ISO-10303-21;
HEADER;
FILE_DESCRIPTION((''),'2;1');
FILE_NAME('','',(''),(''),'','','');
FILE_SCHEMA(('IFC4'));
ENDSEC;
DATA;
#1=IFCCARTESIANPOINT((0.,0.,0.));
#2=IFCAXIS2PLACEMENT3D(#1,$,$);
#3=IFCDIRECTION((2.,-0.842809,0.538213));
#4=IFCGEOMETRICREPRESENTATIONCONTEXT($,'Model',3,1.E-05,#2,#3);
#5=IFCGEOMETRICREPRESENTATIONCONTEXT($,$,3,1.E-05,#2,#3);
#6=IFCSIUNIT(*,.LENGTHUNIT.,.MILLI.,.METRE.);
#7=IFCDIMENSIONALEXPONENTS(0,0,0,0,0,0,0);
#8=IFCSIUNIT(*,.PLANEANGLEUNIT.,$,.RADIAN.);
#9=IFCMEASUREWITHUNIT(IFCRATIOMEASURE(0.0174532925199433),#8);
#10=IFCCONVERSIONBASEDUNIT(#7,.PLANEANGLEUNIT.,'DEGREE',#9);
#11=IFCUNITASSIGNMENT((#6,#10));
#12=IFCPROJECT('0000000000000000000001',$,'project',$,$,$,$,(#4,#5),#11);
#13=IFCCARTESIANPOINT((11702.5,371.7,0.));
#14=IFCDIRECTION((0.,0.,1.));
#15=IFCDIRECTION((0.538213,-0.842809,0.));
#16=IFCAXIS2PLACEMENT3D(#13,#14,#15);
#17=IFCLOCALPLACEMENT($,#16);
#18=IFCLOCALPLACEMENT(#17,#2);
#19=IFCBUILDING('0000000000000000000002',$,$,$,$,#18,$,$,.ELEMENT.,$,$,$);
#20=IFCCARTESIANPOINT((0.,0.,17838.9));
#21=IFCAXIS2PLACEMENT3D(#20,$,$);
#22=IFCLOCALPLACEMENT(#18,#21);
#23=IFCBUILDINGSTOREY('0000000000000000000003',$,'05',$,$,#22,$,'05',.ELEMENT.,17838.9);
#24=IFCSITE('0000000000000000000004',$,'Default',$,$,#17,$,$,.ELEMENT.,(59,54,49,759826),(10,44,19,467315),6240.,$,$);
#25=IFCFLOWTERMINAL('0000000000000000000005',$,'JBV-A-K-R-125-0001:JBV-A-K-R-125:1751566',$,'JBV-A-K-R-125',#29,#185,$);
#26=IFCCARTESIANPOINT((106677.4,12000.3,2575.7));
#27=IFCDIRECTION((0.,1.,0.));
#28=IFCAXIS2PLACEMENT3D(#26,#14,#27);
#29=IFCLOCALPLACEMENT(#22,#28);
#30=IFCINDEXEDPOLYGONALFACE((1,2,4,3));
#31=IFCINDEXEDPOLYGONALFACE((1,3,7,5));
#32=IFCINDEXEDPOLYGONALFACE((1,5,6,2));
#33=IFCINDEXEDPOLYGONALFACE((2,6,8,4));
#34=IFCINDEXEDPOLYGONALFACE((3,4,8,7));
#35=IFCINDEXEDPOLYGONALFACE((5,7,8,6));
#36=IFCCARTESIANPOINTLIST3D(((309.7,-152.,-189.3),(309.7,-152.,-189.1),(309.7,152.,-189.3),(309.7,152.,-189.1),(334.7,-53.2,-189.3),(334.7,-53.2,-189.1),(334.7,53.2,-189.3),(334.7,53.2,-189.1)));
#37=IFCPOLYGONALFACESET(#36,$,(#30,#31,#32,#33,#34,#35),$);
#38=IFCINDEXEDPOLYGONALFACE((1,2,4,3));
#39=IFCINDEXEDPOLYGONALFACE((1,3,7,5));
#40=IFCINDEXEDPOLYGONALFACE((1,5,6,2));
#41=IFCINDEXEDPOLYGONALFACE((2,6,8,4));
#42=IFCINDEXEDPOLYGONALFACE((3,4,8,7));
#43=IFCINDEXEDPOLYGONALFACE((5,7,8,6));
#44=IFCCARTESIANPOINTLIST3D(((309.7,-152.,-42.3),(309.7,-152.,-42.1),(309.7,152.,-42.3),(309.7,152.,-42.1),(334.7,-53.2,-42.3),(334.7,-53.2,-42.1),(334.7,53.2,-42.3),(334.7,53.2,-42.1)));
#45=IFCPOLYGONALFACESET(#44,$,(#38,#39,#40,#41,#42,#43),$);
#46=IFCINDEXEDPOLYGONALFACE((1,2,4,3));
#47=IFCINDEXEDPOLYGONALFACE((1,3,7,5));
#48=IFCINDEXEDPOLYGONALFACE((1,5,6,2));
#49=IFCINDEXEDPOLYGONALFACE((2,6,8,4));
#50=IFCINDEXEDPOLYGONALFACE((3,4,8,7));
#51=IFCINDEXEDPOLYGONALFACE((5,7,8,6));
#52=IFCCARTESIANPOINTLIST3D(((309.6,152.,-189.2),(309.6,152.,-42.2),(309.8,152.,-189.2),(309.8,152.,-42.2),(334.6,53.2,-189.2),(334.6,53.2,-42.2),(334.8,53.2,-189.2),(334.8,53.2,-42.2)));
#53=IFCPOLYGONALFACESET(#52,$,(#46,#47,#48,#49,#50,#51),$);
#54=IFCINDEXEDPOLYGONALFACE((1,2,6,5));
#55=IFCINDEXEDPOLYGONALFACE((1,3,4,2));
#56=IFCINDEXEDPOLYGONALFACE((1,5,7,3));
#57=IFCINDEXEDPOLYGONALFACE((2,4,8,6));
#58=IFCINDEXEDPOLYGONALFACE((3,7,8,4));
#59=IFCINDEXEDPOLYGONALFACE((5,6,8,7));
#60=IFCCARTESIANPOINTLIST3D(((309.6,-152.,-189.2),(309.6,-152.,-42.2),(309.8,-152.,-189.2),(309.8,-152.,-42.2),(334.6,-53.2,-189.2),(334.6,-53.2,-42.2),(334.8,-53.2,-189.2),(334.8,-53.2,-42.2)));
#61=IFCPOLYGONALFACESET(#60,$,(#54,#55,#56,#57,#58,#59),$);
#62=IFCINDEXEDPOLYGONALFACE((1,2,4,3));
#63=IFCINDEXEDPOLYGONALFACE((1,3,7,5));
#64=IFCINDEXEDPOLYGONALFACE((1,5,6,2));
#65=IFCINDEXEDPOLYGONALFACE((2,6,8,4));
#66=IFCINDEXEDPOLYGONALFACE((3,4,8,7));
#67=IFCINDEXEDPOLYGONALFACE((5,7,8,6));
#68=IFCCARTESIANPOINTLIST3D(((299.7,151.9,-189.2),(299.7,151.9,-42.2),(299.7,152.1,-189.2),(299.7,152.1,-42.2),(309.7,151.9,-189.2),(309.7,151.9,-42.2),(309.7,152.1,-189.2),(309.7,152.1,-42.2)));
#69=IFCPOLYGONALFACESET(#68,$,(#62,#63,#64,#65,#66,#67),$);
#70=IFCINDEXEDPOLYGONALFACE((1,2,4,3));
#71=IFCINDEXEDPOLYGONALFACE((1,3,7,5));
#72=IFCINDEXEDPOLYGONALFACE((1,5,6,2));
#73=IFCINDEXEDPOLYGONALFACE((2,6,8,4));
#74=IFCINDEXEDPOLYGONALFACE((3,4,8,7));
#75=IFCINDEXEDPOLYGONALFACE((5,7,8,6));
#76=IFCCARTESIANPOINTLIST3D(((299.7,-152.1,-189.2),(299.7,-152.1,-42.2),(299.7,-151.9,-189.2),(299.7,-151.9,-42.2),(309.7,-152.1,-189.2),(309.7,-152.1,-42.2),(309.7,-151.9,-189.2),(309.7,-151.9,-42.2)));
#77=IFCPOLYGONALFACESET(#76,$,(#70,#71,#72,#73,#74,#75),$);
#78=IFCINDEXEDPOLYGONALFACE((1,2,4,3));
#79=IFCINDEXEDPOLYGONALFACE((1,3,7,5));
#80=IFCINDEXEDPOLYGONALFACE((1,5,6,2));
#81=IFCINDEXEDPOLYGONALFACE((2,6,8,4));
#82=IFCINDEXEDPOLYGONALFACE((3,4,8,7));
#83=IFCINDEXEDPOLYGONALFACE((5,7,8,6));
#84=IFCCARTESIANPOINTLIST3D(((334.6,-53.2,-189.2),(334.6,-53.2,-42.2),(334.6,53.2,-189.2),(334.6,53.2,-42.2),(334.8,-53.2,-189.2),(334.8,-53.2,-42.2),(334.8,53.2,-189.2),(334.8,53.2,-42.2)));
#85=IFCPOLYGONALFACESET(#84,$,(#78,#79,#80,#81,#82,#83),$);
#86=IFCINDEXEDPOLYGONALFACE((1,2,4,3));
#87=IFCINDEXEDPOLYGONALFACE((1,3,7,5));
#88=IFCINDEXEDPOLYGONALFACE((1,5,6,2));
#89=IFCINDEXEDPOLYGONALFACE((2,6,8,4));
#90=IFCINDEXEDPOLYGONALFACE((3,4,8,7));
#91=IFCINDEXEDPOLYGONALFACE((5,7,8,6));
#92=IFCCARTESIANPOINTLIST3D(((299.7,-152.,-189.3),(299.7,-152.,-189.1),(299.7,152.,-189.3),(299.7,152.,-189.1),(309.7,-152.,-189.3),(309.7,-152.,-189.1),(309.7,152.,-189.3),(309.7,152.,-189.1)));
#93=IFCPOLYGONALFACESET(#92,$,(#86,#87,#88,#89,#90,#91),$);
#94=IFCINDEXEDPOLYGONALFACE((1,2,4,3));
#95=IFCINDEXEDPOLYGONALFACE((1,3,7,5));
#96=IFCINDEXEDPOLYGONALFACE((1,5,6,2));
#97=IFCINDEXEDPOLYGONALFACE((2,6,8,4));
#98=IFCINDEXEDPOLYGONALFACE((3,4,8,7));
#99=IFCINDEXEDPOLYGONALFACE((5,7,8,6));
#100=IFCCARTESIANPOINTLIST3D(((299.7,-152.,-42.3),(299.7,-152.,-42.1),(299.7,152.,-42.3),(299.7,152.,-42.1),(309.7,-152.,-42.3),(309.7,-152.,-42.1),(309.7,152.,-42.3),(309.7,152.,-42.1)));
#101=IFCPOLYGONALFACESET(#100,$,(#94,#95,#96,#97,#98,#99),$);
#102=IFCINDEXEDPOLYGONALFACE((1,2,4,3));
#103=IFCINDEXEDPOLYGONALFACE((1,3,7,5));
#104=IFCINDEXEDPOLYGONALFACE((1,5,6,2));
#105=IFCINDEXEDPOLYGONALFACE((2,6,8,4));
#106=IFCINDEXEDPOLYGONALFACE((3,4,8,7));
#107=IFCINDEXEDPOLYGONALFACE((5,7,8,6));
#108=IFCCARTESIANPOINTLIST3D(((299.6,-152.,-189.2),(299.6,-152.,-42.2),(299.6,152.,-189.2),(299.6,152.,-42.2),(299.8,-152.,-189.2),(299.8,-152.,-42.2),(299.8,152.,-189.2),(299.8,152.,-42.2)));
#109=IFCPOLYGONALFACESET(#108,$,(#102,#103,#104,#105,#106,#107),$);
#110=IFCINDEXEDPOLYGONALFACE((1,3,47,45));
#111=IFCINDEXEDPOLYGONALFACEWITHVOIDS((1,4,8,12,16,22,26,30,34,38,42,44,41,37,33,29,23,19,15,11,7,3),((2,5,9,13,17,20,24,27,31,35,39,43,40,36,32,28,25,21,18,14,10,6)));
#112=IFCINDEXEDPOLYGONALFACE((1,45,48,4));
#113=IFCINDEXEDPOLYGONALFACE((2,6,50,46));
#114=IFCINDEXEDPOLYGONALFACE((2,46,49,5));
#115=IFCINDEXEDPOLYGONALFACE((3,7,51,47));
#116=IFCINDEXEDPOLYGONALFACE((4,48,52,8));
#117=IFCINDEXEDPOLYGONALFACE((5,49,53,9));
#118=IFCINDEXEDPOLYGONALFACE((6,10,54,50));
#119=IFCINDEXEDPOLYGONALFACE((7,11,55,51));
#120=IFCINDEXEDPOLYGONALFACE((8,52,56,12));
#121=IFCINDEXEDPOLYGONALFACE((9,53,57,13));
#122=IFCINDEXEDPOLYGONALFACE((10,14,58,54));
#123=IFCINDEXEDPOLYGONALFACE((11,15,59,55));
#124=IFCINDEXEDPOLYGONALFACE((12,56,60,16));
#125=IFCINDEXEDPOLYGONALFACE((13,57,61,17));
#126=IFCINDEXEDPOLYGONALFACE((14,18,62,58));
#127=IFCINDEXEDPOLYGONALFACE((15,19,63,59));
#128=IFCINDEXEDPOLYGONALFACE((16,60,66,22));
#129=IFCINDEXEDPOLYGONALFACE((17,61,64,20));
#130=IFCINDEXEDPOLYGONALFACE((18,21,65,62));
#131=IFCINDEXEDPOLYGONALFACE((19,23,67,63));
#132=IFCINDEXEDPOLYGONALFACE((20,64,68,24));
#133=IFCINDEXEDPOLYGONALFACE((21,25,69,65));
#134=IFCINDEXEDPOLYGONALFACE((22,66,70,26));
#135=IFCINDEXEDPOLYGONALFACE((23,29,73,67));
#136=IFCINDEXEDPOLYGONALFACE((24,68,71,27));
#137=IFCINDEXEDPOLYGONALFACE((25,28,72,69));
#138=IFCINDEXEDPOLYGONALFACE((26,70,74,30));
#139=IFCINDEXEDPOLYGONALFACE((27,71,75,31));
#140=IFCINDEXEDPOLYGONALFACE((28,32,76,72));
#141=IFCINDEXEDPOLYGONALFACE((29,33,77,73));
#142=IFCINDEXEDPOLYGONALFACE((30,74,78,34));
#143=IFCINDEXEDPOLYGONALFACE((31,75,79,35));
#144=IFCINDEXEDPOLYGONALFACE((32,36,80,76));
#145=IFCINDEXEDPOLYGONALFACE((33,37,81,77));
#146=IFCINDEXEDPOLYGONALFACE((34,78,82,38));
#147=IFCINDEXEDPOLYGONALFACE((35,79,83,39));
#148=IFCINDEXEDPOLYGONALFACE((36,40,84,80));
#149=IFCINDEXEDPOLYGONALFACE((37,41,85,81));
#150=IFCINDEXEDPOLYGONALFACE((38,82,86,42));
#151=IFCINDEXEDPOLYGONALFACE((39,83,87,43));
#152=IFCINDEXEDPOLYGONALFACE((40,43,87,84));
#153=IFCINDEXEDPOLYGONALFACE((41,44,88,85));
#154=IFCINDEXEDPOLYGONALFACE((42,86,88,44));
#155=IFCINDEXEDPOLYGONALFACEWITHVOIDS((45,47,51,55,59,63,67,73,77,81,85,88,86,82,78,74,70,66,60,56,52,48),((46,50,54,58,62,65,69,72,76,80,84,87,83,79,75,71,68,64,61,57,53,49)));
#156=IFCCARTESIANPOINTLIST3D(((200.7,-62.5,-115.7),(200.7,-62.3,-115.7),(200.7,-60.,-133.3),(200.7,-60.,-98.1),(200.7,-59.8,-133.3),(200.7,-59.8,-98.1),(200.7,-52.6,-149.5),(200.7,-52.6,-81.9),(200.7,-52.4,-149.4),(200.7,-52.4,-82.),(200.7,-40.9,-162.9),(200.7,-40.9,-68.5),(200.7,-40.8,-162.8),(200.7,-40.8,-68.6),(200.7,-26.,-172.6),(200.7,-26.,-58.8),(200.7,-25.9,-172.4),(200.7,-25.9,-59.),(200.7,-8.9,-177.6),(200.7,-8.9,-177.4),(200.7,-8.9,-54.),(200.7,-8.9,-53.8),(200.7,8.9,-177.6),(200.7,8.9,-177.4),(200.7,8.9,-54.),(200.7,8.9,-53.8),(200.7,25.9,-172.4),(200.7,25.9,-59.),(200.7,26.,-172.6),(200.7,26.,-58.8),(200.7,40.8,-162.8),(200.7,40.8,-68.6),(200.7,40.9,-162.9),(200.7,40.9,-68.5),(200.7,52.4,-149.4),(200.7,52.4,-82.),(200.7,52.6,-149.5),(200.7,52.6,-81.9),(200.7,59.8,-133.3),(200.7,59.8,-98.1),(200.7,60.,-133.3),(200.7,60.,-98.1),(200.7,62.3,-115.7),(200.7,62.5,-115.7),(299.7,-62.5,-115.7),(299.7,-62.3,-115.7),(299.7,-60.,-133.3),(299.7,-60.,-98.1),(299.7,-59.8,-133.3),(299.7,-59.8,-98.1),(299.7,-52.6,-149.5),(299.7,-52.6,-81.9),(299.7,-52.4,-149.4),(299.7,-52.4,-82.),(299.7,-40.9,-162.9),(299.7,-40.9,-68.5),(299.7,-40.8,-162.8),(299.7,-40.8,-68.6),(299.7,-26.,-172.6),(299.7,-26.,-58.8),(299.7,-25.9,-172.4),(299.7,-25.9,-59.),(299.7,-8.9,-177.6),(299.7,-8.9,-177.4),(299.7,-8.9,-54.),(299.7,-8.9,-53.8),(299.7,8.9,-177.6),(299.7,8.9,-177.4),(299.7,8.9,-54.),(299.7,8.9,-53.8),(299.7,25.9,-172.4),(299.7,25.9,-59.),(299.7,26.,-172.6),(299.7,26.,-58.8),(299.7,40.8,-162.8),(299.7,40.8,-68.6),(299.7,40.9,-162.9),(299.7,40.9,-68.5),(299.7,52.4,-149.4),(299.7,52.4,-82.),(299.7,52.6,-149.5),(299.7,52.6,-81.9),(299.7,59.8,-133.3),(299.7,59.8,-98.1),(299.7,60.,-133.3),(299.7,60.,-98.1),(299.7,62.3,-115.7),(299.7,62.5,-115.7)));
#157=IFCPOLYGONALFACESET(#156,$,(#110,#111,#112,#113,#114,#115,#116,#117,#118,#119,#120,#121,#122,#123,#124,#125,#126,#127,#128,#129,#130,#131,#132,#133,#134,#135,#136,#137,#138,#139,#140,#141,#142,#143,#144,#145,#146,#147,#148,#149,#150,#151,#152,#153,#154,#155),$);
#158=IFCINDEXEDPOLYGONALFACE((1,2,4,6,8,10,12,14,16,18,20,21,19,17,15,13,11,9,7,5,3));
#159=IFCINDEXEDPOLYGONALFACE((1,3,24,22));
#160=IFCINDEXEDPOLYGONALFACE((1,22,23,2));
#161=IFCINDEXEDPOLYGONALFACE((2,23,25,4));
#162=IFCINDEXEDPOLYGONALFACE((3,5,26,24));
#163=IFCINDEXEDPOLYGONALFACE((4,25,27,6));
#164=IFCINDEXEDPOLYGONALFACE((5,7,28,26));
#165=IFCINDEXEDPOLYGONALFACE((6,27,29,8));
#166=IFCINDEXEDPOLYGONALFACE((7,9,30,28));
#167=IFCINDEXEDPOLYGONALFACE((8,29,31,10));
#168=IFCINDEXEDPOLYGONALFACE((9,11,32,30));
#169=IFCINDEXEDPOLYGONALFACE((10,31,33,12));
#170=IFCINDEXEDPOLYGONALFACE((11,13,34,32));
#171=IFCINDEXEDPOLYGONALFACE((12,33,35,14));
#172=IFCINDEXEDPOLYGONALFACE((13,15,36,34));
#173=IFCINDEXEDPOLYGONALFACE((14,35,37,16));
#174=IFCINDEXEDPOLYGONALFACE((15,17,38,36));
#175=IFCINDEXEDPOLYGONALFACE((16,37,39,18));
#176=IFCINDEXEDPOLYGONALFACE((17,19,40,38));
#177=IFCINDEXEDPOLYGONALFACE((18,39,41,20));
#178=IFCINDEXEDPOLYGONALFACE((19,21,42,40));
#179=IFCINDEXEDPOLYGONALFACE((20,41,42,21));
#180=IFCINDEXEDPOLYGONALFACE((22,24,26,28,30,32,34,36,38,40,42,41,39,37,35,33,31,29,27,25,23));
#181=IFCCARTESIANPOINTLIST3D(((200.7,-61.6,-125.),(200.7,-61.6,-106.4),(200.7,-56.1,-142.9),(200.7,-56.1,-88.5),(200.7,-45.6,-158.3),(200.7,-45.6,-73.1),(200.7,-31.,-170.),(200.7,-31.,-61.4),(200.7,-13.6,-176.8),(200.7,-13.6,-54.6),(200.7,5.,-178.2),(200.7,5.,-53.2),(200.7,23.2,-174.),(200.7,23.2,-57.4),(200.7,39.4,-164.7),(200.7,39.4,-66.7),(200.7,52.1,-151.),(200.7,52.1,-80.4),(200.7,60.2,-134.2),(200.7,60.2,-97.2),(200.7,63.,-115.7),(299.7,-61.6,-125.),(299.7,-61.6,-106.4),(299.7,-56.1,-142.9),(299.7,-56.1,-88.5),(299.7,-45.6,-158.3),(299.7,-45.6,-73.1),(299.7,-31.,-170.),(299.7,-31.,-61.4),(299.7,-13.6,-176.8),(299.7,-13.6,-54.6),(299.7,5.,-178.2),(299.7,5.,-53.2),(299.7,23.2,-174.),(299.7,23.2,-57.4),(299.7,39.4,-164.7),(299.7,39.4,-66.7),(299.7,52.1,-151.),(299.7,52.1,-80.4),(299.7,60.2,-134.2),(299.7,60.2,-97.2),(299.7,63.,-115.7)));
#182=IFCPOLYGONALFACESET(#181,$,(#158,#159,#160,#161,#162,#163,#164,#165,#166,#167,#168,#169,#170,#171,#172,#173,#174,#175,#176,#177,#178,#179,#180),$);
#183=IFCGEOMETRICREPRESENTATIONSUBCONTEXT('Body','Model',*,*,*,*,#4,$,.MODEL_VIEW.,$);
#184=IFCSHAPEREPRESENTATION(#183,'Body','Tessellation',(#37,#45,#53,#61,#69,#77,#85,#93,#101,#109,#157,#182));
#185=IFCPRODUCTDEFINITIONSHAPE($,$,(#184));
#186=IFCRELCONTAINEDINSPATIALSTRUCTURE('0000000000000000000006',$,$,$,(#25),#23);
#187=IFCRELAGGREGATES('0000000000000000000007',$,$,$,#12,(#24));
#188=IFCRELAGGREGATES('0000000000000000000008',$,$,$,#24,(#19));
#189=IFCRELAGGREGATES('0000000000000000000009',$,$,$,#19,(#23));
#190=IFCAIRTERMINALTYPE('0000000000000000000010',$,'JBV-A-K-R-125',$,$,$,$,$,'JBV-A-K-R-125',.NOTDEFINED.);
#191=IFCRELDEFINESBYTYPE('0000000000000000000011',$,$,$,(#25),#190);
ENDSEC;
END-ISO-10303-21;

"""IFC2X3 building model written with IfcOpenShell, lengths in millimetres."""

from ifc_helpers import new_model, entity, si_unit, converted_unit, direction, frame, frame_2d, origin, origin_2d_with_axis, place, context, subcontext, project, spatial, polyline, circle_curve, parameter, trimmed, segment, composite_curve, rectangle, circle, outline, extrude, source, transform, mapped, type_object, type_shapes, element, save


model = new_model("IFC2X3")

# Units and contexts
model_context = context("Model", 3, precision=1e-05, world=origin(), true_north=direction((2.0, -0.842809, 0.538213)))
context_of_model = context(None, 3, precision=1e-05, world=origin(), true_north=direction((2.0, -0.842809, 0.538213)))
body_context = subcontext(model_context, "Body", "Model", "MODEL_VIEW")
ifc_project = project(units=[si_unit("LENGTHUNIT", "METRE", prefix="MILLI"), converted_unit("PLANEANGLEUNIT", "DEGREE", entity("IfcRatioMeasure", 0.0174532925199433), si_unit("PLANEANGLEUNIT", "RADIAN"), dimensions=[0, 0, 0, 0, 0, 0, 0])], contexts=[model_context, context_of_model])

# Site, building, storey
site_placement = place(None, frame((11702.5, 371.7, 0.0), z_axis=(0.0, 0.0, 1.0), x_axis=(0.538213, -0.842809, 0.0)))
site = spatial("IfcSite", under=ifc_project, at=site_placement, Name="Default", CompositionType="ELEMENT", RefLatitude=(59, 54, 49, 759826), RefLongitude=(10, 44, 19, 467315), RefElevation=6240.0)
building_placement = place(site_placement, origin())
building = spatial("IfcBuilding", under=site, at=building_placement, CompositionType="ELEMENT")
storey_placement = place(building_placement, frame((0.0, 0.0, 17838.9)))
storey = spatial("IfcBuildingStorey", under=building, at=storey_placement, Name="05", LongName="05", CompositionType="ELEMENT", Elevation=17838.9)

# Flow terminal
air_terminal_type_1 = type_object("IfcAirTerminalType", Name="JBV-A-K-R-125", ElementType="JBV-A-K-R-125", PredefinedType="NOTDEFINED")
shared_shape_1 = source(origin(), body_context, "Body", "SweptSolid", [
    extrude(outline(polyline([(-152.0, -12.5), (152.0, -12.5), (53.2, 12.5), (-53.2, 12.5), (-152.0, -12.5)])), frame((322.2, 0.0, -189.3), z_axis=(0.0, 0.0, 1.0), x_axis=(0.0, -1.0, 0.0)), (0.0, 0.0, 1.0), 0.2),
    extrude(outline(polyline([(-152.0, -12.5), (152.0, -12.5), (53.2, 12.5), (-53.2, 12.5), (-152.0, -12.5)])), frame((322.2, 0.0, -42.3), z_axis=(0.0, 0.0, 1.0), x_axis=(0.0, -1.0, 0.0)), (0.0, 0.0, 1.0), 0.2),
    extrude(rectangle(XDim=0.2, YDim=101.9, at=frame_2d((0.0, 0.0), x_axis=(1.0, 0.0))), frame((322.2, 102.6, -189.2), z_axis=(0.0, 0.0, 1.0), x_axis=(0.969446, 0.245305, 0.0)), (0.0, 0.0, 1.0), 147.0),
    extrude(rectangle(XDim=0.2, YDim=101.9, at=frame_2d((0.0, 0.0), x_axis=(1.0, 0.0))), frame((322.2, -102.6, -189.2), z_axis=(0.0, 0.0, 1.0), x_axis=(-0.969446, 0.245305, 0.0)), (0.0, 0.0, 1.0), 147.0),
    extrude(rectangle(XDim=0.2, YDim=10.0, at=frame_2d((0.0, 0.0), x_axis=(1.0, 0.0))), frame((304.7, 152.0, -189.2), z_axis=(0.0, 0.0, 1.0), x_axis=(0.0, 1.0, 0.0)), (0.0, 0.0, 1.0), 147.0),
    extrude(rectangle(XDim=0.2, YDim=10.0, at=frame_2d((0.0, 0.0), x_axis=(1.0, 0.0))), frame((304.7, -152.0, -189.2), z_axis=(0.0, 0.0, 1.0), x_axis=(0.0, 1.0, 0.0)), (0.0, 0.0, 1.0), 147.0),
    extrude(rectangle(XDim=0.2, YDim=106.4, at=frame_2d((0.0, 0.0), x_axis=(1.0, 0.0))), frame((334.7, 0.0, -189.2)), (0.0, 0.0, 1.0), 147.0),
    extrude(rectangle(XDim=304.0, YDim=10.0, at=frame_2d((0.0, 0.0), x_axis=(1.0, 0.0))), frame((304.7, 0.0, -189.3), z_axis=(0.0, 0.0, 1.0), x_axis=(0.0, -1.0, 0.0)), (0.0, 0.0, 1.0), 0.2),
    extrude(rectangle(XDim=304.0, YDim=10.0, at=frame_2d((0.0, 0.0), x_axis=(1.0, 0.0))), frame((304.7, 0.0, -42.3), z_axis=(0.0, 0.0, 1.0), x_axis=(0.0, -1.0, 0.0)), (0.0, 0.0, 1.0), 0.2),
    extrude(rectangle(XDim=0.2, YDim=304.0, at=frame_2d((0.0, 0.0), x_axis=(1.0, 0.0))), frame((299.7, 0.0, -189.2)), (0.0, 0.0, 1.0), 147.0),
    extrude(outline(composite_curve([segment(trimmed(circle_curve(origin_2d_with_axis(), 62.5), [parameter(0.0)], [parameter(180.0)], True, "PARAMETER"), True, "CONTINUOUS"), segment(trimmed(circle_curve(origin_2d_with_axis(), 62.5), [parameter(180.0)], [parameter(360.0)], True, "PARAMETER"), True, "CONTINUOUS")], self_intersect=False), holes=[composite_curve([segment(trimmed(circle_curve(origin_2d_with_axis(), 62.3), [parameter(180.0)], [parameter(360.0)], True, "PARAMETER"), False, "CONTINUOUS"), segment(trimmed(circle_curve(origin_2d_with_axis(), 62.3), [parameter(0.0)], [parameter(180.0)], True, "PARAMETER"), False, "CONTINUOUS")], self_intersect=False)]), frame((200.7, 0.0, -115.7), z_axis=(1.0, 0.0, 0.0), x_axis=(0.0, 1.0, 0.0)), (0.0, 0.0, 1.0), 99.0),
    extrude(circle(Radius=62.6, at=frame_2d((0.0, 0.0), x_axis=(1.0, 0.0))), frame((200.7, 0.3, -115.7), z_axis=(1.0, 0.0, 0.0), x_axis=(0.0, 1.0, 0.0)), (0.0, 0.0, 1.0), 99.0),
])
type_shapes(air_terminal_type_1, [shared_shape_1])
for number, where, z_axis, x_axis, name in (
    (1, (106677.4, 12000.3, 2575.7), (0.0, 0.0, 1.0), (0.0, 1.0, 0.0), "JBV-A-K-R-125-0001:JBV-A-K-R-125:1751566"),
):
    element("IfcFlowTerminal", number, at=place(storey_placement, frame(where, z_axis=z_axis, x_axis=x_axis)), inside=storey, type_object=air_terminal_type_1, Name=name, ObjectType="JBV-A-K-R-125", context=body_context, shape_type="MappedRepresentation", body=[
        mapped(shared_shape_1, transform((0.0, 0.0, 0.0), scale=1.0)),
    ])

save(model, "model.ifc")
